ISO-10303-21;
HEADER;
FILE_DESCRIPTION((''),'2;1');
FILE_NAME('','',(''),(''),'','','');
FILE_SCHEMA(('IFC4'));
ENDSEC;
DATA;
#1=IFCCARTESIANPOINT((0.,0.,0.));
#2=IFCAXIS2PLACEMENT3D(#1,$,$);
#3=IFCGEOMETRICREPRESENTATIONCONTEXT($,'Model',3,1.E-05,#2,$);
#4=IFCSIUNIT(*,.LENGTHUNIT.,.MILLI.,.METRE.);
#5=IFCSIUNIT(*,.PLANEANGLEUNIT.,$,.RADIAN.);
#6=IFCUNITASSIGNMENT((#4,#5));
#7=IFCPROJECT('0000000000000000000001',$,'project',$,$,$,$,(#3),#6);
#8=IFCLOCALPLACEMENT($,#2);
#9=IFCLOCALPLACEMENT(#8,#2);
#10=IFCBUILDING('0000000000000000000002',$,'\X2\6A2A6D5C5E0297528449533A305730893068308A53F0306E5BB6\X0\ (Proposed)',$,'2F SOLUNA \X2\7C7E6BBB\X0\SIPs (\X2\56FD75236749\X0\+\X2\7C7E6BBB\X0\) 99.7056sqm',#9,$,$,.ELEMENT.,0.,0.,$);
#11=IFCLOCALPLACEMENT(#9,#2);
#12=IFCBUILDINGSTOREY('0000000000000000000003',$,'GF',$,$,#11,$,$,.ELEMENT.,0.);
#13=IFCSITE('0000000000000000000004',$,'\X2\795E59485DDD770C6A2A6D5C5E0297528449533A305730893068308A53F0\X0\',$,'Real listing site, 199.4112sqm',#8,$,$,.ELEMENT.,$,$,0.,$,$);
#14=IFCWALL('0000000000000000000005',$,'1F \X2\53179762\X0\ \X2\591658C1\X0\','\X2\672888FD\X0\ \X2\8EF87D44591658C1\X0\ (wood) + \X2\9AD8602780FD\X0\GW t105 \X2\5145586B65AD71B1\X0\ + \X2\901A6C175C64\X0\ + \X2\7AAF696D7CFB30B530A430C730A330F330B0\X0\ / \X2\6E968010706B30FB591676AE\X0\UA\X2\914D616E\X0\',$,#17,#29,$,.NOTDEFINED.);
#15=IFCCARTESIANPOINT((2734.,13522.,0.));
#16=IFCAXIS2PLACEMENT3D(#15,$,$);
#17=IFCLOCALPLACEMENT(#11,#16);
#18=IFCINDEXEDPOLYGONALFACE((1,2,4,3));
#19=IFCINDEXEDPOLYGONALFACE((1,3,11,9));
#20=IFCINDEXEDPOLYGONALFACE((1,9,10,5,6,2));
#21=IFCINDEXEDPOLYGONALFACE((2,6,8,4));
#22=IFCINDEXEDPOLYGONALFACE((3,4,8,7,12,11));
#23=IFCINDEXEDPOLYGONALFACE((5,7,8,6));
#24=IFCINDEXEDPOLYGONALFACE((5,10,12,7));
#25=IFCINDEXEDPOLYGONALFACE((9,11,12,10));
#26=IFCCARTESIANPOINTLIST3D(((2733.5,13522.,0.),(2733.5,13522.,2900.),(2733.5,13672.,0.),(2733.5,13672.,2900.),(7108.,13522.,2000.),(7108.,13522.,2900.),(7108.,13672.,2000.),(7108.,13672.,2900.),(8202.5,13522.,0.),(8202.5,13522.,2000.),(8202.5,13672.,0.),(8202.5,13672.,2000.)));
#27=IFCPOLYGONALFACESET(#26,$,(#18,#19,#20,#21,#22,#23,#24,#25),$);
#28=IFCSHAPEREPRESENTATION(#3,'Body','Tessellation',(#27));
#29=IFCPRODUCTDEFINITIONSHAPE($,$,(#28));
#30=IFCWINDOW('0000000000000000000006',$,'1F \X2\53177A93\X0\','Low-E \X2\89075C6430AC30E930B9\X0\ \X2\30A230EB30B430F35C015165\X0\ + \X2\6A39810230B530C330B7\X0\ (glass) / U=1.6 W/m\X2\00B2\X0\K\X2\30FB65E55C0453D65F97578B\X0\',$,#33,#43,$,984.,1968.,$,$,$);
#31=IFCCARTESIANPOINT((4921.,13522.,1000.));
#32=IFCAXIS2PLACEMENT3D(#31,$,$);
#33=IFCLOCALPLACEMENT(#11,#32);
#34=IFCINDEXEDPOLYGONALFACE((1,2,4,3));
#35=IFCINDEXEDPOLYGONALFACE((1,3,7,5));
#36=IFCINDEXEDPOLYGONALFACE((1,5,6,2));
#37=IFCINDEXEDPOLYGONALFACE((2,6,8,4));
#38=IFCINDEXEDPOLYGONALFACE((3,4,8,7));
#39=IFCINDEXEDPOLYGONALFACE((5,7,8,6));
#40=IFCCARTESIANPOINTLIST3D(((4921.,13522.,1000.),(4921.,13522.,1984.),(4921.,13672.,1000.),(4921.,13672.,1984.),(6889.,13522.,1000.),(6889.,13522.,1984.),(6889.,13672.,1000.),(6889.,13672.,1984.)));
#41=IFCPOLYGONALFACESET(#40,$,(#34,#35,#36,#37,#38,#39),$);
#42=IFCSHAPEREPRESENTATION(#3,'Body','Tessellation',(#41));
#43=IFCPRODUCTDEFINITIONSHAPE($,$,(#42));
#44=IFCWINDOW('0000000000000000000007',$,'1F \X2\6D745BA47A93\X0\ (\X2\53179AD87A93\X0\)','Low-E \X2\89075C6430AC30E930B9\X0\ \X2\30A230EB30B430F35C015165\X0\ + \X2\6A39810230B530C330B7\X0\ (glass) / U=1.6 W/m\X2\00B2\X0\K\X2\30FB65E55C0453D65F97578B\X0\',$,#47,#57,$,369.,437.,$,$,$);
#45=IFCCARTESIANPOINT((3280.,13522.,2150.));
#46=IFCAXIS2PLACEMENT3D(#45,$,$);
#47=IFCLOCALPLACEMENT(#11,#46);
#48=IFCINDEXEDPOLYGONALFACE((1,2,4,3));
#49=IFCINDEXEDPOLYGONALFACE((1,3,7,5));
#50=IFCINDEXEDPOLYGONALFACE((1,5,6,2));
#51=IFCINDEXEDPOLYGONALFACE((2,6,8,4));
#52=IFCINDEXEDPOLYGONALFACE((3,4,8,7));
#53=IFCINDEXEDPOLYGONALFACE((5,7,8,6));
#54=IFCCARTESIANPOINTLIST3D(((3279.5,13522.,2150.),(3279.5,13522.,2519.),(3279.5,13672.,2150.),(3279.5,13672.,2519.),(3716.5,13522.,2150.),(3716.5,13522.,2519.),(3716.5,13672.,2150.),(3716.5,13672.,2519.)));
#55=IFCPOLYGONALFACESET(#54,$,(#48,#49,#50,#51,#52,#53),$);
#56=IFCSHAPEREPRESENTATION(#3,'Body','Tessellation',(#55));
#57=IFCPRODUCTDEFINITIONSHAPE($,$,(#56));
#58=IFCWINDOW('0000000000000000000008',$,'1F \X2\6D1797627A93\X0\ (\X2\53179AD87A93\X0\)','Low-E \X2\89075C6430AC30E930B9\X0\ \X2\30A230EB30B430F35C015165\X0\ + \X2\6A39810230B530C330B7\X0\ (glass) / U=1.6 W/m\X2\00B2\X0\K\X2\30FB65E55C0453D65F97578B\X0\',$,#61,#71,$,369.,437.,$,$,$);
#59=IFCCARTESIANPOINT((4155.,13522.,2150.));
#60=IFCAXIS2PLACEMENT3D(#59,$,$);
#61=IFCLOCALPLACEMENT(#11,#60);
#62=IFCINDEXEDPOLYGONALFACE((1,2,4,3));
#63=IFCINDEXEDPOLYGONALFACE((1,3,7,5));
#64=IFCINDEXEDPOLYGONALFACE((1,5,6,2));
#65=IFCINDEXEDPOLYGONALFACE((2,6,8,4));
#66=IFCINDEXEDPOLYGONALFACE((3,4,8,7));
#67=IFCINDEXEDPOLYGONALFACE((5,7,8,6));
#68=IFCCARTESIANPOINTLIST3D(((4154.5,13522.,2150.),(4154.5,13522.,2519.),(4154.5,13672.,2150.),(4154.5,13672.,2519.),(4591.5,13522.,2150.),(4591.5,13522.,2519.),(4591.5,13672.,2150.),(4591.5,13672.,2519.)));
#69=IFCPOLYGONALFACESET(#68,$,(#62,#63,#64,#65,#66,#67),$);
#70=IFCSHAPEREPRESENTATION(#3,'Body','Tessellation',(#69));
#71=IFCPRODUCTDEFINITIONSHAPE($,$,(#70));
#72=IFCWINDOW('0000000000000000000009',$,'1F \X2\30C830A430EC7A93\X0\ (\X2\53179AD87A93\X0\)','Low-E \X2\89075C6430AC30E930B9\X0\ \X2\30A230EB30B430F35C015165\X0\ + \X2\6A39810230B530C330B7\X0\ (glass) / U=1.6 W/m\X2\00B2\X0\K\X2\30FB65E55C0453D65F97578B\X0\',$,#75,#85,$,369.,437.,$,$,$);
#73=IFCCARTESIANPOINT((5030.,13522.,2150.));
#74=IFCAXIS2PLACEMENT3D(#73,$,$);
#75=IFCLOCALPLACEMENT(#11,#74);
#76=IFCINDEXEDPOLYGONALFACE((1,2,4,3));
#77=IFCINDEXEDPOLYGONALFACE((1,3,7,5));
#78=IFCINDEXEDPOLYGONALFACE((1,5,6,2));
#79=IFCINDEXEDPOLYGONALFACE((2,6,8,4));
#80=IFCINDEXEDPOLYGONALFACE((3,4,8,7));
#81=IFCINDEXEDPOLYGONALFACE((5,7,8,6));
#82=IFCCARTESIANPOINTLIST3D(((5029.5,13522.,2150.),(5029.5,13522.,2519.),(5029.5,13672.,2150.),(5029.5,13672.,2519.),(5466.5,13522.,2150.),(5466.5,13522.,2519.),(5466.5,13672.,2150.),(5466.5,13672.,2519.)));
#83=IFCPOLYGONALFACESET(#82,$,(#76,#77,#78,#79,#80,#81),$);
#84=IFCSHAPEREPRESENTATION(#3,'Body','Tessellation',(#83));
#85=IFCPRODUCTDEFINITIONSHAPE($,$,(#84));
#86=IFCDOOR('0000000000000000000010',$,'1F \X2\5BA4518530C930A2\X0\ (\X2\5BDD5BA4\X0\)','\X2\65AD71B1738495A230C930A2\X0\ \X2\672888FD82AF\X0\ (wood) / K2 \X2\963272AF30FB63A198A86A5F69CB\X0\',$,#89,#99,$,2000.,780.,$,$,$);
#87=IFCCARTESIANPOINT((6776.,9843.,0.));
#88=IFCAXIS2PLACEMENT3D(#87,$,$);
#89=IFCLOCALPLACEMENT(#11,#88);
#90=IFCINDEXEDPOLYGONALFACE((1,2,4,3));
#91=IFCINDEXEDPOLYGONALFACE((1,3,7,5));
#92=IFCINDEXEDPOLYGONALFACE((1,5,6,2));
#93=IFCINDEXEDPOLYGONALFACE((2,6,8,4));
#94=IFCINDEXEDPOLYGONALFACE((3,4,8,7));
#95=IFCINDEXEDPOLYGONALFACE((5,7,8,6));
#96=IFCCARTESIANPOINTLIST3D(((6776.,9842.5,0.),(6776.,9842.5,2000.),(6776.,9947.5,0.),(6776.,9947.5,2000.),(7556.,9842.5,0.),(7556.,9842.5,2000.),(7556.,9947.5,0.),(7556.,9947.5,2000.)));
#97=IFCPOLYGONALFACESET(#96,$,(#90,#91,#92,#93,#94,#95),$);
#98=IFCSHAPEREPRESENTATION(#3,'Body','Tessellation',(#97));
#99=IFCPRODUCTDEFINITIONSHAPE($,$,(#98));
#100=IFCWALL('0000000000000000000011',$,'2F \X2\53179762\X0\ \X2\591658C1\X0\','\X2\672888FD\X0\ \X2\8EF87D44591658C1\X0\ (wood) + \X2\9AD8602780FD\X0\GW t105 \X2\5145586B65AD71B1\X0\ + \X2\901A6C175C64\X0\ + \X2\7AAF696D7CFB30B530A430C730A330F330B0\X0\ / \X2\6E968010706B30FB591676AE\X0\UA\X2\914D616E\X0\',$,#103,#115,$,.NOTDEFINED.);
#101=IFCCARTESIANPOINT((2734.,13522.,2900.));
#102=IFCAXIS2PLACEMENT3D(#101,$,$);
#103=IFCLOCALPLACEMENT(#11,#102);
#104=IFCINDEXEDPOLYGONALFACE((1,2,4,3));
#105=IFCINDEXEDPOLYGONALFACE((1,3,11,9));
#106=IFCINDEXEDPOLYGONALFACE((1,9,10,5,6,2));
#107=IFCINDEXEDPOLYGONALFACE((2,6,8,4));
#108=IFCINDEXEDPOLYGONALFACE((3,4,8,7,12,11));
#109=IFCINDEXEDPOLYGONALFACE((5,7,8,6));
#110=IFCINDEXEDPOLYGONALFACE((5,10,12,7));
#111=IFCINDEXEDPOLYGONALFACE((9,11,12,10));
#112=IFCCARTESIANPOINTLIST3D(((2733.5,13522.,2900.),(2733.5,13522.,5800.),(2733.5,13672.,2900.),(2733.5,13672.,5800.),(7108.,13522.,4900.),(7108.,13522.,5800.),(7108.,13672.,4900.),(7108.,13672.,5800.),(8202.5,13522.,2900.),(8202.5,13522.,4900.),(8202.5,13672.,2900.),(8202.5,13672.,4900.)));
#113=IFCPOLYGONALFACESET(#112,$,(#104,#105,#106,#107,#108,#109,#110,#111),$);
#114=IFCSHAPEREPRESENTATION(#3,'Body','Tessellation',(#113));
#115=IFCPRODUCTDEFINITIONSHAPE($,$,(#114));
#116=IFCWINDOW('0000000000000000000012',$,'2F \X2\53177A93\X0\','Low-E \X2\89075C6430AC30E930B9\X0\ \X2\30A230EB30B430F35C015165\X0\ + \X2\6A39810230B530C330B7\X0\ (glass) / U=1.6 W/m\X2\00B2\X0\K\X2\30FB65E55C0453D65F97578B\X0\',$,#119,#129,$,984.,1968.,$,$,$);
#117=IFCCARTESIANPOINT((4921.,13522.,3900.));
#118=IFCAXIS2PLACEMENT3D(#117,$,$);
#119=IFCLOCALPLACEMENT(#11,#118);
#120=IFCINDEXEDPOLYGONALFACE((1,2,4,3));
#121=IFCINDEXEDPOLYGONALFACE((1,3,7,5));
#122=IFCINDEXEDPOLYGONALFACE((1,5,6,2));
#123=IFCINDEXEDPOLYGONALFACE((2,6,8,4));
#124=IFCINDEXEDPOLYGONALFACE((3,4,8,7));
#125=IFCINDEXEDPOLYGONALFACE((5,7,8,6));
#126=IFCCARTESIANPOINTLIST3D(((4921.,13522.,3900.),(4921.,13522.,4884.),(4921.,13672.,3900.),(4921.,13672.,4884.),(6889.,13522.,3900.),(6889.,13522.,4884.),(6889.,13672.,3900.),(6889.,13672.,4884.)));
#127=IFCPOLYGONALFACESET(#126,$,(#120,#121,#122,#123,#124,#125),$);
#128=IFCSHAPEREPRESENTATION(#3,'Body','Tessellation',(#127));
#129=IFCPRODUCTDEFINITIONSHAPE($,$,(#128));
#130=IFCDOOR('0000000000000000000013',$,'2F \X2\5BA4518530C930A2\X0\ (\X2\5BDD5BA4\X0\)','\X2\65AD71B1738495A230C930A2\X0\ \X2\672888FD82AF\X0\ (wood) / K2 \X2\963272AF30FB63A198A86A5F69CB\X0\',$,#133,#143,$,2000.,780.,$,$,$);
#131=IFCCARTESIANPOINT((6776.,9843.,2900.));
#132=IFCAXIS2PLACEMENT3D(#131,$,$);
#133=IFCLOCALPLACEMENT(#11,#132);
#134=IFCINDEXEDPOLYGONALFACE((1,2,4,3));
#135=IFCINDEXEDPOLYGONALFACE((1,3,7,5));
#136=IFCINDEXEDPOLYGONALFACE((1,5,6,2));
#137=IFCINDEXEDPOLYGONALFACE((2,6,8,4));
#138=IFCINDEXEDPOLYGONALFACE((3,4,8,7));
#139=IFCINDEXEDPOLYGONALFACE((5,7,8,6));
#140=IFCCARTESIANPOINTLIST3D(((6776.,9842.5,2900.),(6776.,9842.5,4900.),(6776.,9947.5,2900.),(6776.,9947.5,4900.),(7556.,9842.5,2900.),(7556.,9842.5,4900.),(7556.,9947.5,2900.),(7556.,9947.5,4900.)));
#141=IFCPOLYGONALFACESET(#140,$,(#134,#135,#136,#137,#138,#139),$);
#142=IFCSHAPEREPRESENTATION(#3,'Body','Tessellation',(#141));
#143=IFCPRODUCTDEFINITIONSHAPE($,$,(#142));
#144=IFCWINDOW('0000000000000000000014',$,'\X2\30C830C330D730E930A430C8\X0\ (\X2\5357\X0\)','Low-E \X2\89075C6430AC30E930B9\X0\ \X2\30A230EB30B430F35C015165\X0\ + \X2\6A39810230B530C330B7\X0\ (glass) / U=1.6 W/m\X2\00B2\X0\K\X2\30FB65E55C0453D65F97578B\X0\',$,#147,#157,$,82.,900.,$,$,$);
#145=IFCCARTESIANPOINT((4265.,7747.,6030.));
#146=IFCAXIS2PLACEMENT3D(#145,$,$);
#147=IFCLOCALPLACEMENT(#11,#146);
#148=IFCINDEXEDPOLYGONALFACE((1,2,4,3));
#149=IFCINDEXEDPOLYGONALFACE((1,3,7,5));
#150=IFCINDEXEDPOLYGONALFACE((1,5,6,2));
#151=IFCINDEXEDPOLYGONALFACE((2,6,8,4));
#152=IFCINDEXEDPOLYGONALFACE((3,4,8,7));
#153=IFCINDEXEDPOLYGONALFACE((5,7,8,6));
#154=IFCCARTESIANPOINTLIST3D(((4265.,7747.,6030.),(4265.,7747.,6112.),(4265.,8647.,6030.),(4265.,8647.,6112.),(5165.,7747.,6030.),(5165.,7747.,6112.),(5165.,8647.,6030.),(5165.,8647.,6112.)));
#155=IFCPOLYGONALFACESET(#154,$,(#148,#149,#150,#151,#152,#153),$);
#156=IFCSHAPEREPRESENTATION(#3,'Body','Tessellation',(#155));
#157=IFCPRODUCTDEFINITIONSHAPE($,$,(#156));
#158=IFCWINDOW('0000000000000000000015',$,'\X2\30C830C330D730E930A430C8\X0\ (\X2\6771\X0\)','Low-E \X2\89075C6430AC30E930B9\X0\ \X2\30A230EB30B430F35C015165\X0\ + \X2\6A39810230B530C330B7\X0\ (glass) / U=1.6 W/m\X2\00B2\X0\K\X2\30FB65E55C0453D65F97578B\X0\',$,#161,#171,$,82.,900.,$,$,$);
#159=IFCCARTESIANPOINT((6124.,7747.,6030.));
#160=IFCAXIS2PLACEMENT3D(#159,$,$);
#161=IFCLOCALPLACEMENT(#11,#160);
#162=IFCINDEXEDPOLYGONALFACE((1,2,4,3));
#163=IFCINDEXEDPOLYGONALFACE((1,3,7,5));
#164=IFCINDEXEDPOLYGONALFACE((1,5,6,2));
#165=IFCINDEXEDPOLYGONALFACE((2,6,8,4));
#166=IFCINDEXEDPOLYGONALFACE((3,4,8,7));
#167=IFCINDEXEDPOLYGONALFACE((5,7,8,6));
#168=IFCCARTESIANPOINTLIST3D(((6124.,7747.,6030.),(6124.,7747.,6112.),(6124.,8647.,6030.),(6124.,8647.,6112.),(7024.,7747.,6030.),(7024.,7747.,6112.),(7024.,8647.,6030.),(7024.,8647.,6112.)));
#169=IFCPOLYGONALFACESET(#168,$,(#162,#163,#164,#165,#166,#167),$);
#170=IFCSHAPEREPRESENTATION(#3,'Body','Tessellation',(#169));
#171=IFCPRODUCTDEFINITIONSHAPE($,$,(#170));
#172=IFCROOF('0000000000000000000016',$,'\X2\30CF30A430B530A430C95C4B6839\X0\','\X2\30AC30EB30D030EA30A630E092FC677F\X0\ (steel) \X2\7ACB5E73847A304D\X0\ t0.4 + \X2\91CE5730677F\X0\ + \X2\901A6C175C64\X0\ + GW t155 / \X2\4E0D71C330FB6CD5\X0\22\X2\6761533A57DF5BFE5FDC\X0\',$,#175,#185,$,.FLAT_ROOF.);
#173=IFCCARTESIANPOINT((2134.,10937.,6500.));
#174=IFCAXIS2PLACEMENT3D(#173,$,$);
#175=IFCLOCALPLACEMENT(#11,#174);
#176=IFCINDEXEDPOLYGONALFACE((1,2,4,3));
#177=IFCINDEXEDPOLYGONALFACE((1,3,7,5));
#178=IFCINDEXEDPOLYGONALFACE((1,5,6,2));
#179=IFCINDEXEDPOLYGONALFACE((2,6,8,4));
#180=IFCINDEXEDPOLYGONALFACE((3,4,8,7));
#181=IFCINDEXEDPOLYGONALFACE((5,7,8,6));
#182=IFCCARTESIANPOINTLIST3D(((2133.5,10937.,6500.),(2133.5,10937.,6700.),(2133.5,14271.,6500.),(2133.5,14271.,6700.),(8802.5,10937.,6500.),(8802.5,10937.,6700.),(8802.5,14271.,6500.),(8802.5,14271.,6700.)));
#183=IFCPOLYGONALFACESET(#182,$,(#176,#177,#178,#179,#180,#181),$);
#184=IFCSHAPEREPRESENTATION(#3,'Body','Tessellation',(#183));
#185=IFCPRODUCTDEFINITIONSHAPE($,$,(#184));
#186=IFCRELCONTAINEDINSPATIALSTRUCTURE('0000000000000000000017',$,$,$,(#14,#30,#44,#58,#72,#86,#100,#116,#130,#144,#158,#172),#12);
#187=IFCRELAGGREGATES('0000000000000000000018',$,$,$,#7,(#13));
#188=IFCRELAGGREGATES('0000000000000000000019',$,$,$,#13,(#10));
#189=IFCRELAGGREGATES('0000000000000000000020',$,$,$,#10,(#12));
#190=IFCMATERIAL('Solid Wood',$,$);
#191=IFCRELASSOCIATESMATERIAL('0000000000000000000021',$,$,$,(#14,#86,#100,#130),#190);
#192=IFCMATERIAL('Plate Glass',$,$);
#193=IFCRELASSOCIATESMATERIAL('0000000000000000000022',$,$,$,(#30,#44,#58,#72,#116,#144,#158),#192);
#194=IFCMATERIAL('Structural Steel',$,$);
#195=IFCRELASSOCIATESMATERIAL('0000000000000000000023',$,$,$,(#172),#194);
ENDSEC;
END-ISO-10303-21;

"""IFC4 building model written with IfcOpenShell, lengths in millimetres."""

from ifc_helpers import new_model, si_unit, frame, frame_2d, origin, place, context, project, spatial, rectangle, extrude, material, element, fill, save


model = new_model("IFC4")

# Units and contexts
model_context = context("Model", 3, precision=1e-05, world=origin())
ifc_project = project(units=[si_unit("LENGTHUNIT", "METRE", prefix="MILLI"), si_unit("PLANEANGLEUNIT", "RADIAN")], contexts=[model_context])

# Site, building, storey
site_placement = place(None, origin())
site = spatial("IfcSite", under=ifc_project, at=site_placement, Name="神奈川県横浜市青葉区しらとり台", ObjectType="Real listing site, 199.4112sqm", CompositionType="ELEMENT", RefElevation=0.0)
building_placement = place(site_placement, origin())
building = spatial("IfcBuilding", under=site, at=building_placement, Name="横浜市青葉区しらとり台の家 (Proposed)", ObjectType="2F SOLUNA 籾殻SIPs (国産杉+籾殻) 99.7056sqm", CompositionType="ELEMENT", ElevationOfRefHeight=0.0, ElevationOfTerrain=0.0)
storey_placement = place(building_placement, origin())
storey = spatial("IfcBuildingStorey", under=building, at=storey_placement, Name="GF", CompositionType="ELEMENT", Elevation=0.0)

# Wall, openings, windows
ifc_material_1 = material(Name="Solid Wood")
wall_1_placement = place(storey_placement, frame((2734.0, 13522.0, 0.0)))
wall_1 = element("IfcWall", 1, at=wall_1_placement, inside=storey, material=ifc_material_1, Name="1F 北面 外壁", Description="木製 軸組外壁 (wood) + 高性能GW t105 充填断熱 + 通気層 + 窯業系サイディング / 準耐火・外皮UA配慮", PredefinedType="NOTDEFINED", context=model_context, shape_type="SweptSolid", body=[
    extrude(rectangle(XDim=5469.0, YDim=150.0, at=frame_2d((2734.0, 75.0))), frame((2734.0, 13522.0, 0.0)), (0.0, 0.0, 1.0), 2900.0),
])
opening_1_placement = place(storey_placement, frame((4921.0, 13522.0, 1000.0)))
opening_1 = element("IfcOpeningElement", 2, at=opening_1_placement, cuts=wall_1, PredefinedType="NOTDEFINED", context=model_context, shape_type="SweptSolid", body=[
    extrude(rectangle(XDim=1968.0, YDim=150.0, at=frame_2d((984.0, 75.0))), frame((4921.0, 13522.0, 1000.0)), (0.0, 0.0, 1.0), 984.0),
])
opening_2_placement = place(storey_placement, frame((3280.0, 13522.0, 2150.0)))
opening_2 = element("IfcOpeningElement", 3, at=opening_2_placement, cuts=wall_1, PredefinedType="NOTDEFINED", context=model_context, shape_type="SweptSolid", body=[
    extrude(rectangle(XDim=437.0, YDim=150.0, at=frame_2d((218.0, 75.0))), frame((3280.0, 13522.0, 2150.0)), (0.0, 0.0, 1.0), 369.0),
])
opening_3_placement = place(storey_placement, frame((4155.0, 13522.0, 2150.0)))
opening_3 = element("IfcOpeningElement", 4, at=opening_3_placement, cuts=wall_1, PredefinedType="NOTDEFINED", context=model_context, shape_type="SweptSolid", body=[
    extrude(rectangle(XDim=437.0, YDim=150.0, at=frame_2d((218.0, 75.0))), frame((4155.0, 13522.0, 2150.0)), (0.0, 0.0, 1.0), 369.0),
])
opening_4_placement = place(storey_placement, frame((5030.0, 13522.0, 2150.0)))
opening_4 = element("IfcOpeningElement", 5, at=opening_4_placement, cuts=wall_1, PredefinedType="NOTDEFINED", context=model_context, shape_type="SweptSolid", body=[
    extrude(rectangle(XDim=437.0, YDim=150.0, at=frame_2d((218.0, 75.0))), frame((5030.0, 13522.0, 2150.0)), (0.0, 0.0, 1.0), 369.0),
])
ifc_material_2 = material(Name="Plate Glass")
window_1_placement = place(storey_placement, frame((4921.0, 13522.0, 1000.0)))
window_1 = element("IfcWindow", 6, at=window_1_placement, inside=storey, material=ifc_material_2, Name="1F 北窓", Description="Low-E 複層ガラス アルゴン封入 + 樹脂サッシ (glass) / U=1.6 W/m²K・日射取得型", OverallHeight=984.0, OverallWidth=1968.0, context=model_context, shape_type="SweptSolid", body=[
    extrude(rectangle(XDim=1968.0, YDim=150.0, at=frame_2d((984.0, 75.0))), frame((4921.0, 13522.0, 1000.0)), (0.0, 0.0, 1.0), 984.0),
])
fill(opening_1, window_1)
window_2_placement = place(storey_placement, frame((3280.0, 13522.0, 2150.0)))
window_2 = element("IfcWindow", 7, at=window_2_placement, inside=storey, material=ifc_material_2, Name="1F 浴室窓 (北高窓)", Description="Low-E 複層ガラス アルゴン封入 + 樹脂サッシ (glass) / U=1.6 W/m²K・日射取得型", OverallHeight=369.0, OverallWidth=437.0, context=model_context, shape_type="SweptSolid", body=[
    extrude(rectangle(XDim=437.0, YDim=150.0, at=frame_2d((218.0, 75.0))), frame((3280.0, 13522.0, 2150.0)), (0.0, 0.0, 1.0), 369.0),
])
fill(opening_2, window_2)
window_3_placement = place(storey_placement, frame((4155.0, 13522.0, 2150.0)))
window_3 = element("IfcWindow", 8, at=window_3_placement, inside=storey, material=ifc_material_2, Name="1F 洗面窓 (北高窓)", Description="Low-E 複層ガラス アルゴン封入 + 樹脂サッシ (glass) / U=1.6 W/m²K・日射取得型", OverallHeight=369.0, OverallWidth=437.0, context=model_context, shape_type="SweptSolid", body=[
    extrude(rectangle(XDim=437.0, YDim=150.0, at=frame_2d((218.0, 75.0))), frame((4155.0, 13522.0, 2150.0)), (0.0, 0.0, 1.0), 369.0),
])
fill(opening_3, window_3)
window_4_placement = place(storey_placement, frame((5030.0, 13522.0, 2150.0)))
window_4 = element("IfcWindow", 9, at=window_4_placement, inside=storey, material=ifc_material_2, Name="1F トイレ窓 (北高窓)", Description="Low-E 複層ガラス アルゴン封入 + 樹脂サッシ (glass) / U=1.6 W/m²K・日射取得型", OverallHeight=369.0, OverallWidth=437.0, context=model_context, shape_type="SweptSolid", body=[
    extrude(rectangle(XDim=437.0, YDim=150.0, at=frame_2d((218.0, 75.0))), frame((5030.0, 13522.0, 2150.0)), (0.0, 0.0, 1.0), 369.0),
])
fill(opening_4, window_4)

# Door
door_1_placement = place(storey_placement, frame((6776.0, 9843.0, 0.0)))
element("IfcDoor", 10, at=door_1_placement, inside=storey, material=ifc_material_1, Name="1F 室内ドア (寝室)", Description="断熱玄関ドア 木製芯 (wood) / K2 防犯・採風機構", OverallHeight=2000.0, OverallWidth=780.0, context=model_context, shape_type="SweptSolid", body=[
    extrude(rectangle(XDim=780.0, YDim=105.0, at=frame_2d((390.0, 52.0))), frame((6776.0, 9843.0, 0.0)), (0.0, 0.0, 1.0), 2000.0),
])

# Wall, opening, window
wall_2_placement = place(storey_placement, frame((2734.0, 13522.0, 2900.0)))
wall_2 = element("IfcWall", 11, at=wall_2_placement, inside=storey, material=ifc_material_1, Name="2F 北面 外壁", Description="木製 軸組外壁 (wood) + 高性能GW t105 充填断熱 + 通気層 + 窯業系サイディング / 準耐火・外皮UA配慮", PredefinedType="NOTDEFINED", context=model_context, shape_type="SweptSolid", body=[
    extrude(rectangle(XDim=5469.0, YDim=150.0, at=frame_2d((2734.0, 75.0))), frame((2734.0, 13522.0, 2900.0)), (0.0, 0.0, 1.0), 2900.0),
])
opening_5_placement = place(storey_placement, frame((4921.0, 13522.0, 3900.0)))
opening_5 = element("IfcOpeningElement", 12, at=opening_5_placement, cuts=wall_2, PredefinedType="NOTDEFINED", context=model_context, shape_type="SweptSolid", body=[
    extrude(rectangle(XDim=1968.0, YDim=150.0, at=frame_2d((984.0, 75.0))), frame((4921.0, 13522.0, 3900.0)), (0.0, 0.0, 1.0), 984.0),
])
window_5_placement = place(storey_placement, frame((4921.0, 13522.0, 3900.0)))
window_5 = element("IfcWindow", 13, at=window_5_placement, inside=storey, material=ifc_material_2, Name="2F 北窓", Description="Low-E 複層ガラス アルゴン封入 + 樹脂サッシ (glass) / U=1.6 W/m²K・日射取得型", OverallHeight=984.0, OverallWidth=1968.0, context=model_context, shape_type="SweptSolid", body=[
    extrude(rectangle(XDim=1968.0, YDim=150.0, at=frame_2d((984.0, 75.0))), frame((4921.0, 13522.0, 3900.0)), (0.0, 0.0, 1.0), 984.0),
])
fill(opening_5, window_5)

# Door
door_2_placement = place(storey_placement, frame((6776.0, 9843.0, 2900.0)))
element("IfcDoor", 14, at=door_2_placement, inside=storey, material=ifc_material_1, Name="2F 室内ドア (寝室)", Description="断熱玄関ドア 木製芯 (wood) / K2 防犯・採風機構", OverallHeight=2000.0, OverallWidth=780.0, context=model_context, shape_type="SweptSolid", body=[
    extrude(rectangle(XDim=780.0, YDim=105.0, at=frame_2d((390.0, 52.0))), frame((6776.0, 9843.0, 2900.0)), (0.0, 0.0, 1.0), 2000.0),
])

# Windows
window_6_placement = place(storey_placement, frame((4265.0, 7747.0, 6030.0)))
element("IfcWindow", 15, at=window_6_placement, inside=storey, material=ifc_material_2, Name="トップライト (南)", Description="Low-E 複層ガラス アルゴン封入 + 樹脂サッシ (glass) / U=1.6 W/m²K・日射取得型", OverallHeight=82.0, OverallWidth=900.0, context=model_context, shape_type="SweptSolid", body=[
    extrude(rectangle(XDim=900.0, YDim=900.0, at=frame_2d((450.0, 450.0))), frame((4265.0, 7747.0, 6030.0)), (0.0, 0.0, 1.0), 82.0),
])
window_7_placement = place(storey_placement, frame((6124.0, 7747.0, 6030.0)))
element("IfcWindow", 16, at=window_7_placement, inside=storey, material=ifc_material_2, Name="トップライト (東)", Description="Low-E 複層ガラス アルゴン封入 + 樹脂サッシ (glass) / U=1.6 W/m²K・日射取得型", OverallHeight=82.0, OverallWidth=900.0, context=model_context, shape_type="SweptSolid", body=[
    extrude(rectangle(XDim=900.0, YDim=900.0, at=frame_2d((450.0, 450.0))), frame((6124.0, 7747.0, 6030.0)), (0.0, 0.0, 1.0), 82.0),
])

# Roof
ifc_material_3 = material(Name="Structural Steel")
roof_placement = place(storey_placement, frame((2134.0, 10937.0, 6500.0)))
element("IfcRoof", 17, at=roof_placement, inside=storey, material=ifc_material_3, Name="ハイサイド屋根", Description="ガルバリウム鋼板 (steel) 立平葺き t0.4 + 野地板 + 通気層 + GW t155 / 不燃・法22条区域対応", PredefinedType="FLAT_ROOF", context=model_context, shape_type="SweptSolid", body=[
    extrude(rectangle(XDim=6669.0, YDim=3334.0, at=frame_2d((3334.0, 1667.0))), frame((2134.0, 10937.0, 6500.0)), (0.0, 0.0, 1.0), 200.0),
])

save(model, "model.ifc")
